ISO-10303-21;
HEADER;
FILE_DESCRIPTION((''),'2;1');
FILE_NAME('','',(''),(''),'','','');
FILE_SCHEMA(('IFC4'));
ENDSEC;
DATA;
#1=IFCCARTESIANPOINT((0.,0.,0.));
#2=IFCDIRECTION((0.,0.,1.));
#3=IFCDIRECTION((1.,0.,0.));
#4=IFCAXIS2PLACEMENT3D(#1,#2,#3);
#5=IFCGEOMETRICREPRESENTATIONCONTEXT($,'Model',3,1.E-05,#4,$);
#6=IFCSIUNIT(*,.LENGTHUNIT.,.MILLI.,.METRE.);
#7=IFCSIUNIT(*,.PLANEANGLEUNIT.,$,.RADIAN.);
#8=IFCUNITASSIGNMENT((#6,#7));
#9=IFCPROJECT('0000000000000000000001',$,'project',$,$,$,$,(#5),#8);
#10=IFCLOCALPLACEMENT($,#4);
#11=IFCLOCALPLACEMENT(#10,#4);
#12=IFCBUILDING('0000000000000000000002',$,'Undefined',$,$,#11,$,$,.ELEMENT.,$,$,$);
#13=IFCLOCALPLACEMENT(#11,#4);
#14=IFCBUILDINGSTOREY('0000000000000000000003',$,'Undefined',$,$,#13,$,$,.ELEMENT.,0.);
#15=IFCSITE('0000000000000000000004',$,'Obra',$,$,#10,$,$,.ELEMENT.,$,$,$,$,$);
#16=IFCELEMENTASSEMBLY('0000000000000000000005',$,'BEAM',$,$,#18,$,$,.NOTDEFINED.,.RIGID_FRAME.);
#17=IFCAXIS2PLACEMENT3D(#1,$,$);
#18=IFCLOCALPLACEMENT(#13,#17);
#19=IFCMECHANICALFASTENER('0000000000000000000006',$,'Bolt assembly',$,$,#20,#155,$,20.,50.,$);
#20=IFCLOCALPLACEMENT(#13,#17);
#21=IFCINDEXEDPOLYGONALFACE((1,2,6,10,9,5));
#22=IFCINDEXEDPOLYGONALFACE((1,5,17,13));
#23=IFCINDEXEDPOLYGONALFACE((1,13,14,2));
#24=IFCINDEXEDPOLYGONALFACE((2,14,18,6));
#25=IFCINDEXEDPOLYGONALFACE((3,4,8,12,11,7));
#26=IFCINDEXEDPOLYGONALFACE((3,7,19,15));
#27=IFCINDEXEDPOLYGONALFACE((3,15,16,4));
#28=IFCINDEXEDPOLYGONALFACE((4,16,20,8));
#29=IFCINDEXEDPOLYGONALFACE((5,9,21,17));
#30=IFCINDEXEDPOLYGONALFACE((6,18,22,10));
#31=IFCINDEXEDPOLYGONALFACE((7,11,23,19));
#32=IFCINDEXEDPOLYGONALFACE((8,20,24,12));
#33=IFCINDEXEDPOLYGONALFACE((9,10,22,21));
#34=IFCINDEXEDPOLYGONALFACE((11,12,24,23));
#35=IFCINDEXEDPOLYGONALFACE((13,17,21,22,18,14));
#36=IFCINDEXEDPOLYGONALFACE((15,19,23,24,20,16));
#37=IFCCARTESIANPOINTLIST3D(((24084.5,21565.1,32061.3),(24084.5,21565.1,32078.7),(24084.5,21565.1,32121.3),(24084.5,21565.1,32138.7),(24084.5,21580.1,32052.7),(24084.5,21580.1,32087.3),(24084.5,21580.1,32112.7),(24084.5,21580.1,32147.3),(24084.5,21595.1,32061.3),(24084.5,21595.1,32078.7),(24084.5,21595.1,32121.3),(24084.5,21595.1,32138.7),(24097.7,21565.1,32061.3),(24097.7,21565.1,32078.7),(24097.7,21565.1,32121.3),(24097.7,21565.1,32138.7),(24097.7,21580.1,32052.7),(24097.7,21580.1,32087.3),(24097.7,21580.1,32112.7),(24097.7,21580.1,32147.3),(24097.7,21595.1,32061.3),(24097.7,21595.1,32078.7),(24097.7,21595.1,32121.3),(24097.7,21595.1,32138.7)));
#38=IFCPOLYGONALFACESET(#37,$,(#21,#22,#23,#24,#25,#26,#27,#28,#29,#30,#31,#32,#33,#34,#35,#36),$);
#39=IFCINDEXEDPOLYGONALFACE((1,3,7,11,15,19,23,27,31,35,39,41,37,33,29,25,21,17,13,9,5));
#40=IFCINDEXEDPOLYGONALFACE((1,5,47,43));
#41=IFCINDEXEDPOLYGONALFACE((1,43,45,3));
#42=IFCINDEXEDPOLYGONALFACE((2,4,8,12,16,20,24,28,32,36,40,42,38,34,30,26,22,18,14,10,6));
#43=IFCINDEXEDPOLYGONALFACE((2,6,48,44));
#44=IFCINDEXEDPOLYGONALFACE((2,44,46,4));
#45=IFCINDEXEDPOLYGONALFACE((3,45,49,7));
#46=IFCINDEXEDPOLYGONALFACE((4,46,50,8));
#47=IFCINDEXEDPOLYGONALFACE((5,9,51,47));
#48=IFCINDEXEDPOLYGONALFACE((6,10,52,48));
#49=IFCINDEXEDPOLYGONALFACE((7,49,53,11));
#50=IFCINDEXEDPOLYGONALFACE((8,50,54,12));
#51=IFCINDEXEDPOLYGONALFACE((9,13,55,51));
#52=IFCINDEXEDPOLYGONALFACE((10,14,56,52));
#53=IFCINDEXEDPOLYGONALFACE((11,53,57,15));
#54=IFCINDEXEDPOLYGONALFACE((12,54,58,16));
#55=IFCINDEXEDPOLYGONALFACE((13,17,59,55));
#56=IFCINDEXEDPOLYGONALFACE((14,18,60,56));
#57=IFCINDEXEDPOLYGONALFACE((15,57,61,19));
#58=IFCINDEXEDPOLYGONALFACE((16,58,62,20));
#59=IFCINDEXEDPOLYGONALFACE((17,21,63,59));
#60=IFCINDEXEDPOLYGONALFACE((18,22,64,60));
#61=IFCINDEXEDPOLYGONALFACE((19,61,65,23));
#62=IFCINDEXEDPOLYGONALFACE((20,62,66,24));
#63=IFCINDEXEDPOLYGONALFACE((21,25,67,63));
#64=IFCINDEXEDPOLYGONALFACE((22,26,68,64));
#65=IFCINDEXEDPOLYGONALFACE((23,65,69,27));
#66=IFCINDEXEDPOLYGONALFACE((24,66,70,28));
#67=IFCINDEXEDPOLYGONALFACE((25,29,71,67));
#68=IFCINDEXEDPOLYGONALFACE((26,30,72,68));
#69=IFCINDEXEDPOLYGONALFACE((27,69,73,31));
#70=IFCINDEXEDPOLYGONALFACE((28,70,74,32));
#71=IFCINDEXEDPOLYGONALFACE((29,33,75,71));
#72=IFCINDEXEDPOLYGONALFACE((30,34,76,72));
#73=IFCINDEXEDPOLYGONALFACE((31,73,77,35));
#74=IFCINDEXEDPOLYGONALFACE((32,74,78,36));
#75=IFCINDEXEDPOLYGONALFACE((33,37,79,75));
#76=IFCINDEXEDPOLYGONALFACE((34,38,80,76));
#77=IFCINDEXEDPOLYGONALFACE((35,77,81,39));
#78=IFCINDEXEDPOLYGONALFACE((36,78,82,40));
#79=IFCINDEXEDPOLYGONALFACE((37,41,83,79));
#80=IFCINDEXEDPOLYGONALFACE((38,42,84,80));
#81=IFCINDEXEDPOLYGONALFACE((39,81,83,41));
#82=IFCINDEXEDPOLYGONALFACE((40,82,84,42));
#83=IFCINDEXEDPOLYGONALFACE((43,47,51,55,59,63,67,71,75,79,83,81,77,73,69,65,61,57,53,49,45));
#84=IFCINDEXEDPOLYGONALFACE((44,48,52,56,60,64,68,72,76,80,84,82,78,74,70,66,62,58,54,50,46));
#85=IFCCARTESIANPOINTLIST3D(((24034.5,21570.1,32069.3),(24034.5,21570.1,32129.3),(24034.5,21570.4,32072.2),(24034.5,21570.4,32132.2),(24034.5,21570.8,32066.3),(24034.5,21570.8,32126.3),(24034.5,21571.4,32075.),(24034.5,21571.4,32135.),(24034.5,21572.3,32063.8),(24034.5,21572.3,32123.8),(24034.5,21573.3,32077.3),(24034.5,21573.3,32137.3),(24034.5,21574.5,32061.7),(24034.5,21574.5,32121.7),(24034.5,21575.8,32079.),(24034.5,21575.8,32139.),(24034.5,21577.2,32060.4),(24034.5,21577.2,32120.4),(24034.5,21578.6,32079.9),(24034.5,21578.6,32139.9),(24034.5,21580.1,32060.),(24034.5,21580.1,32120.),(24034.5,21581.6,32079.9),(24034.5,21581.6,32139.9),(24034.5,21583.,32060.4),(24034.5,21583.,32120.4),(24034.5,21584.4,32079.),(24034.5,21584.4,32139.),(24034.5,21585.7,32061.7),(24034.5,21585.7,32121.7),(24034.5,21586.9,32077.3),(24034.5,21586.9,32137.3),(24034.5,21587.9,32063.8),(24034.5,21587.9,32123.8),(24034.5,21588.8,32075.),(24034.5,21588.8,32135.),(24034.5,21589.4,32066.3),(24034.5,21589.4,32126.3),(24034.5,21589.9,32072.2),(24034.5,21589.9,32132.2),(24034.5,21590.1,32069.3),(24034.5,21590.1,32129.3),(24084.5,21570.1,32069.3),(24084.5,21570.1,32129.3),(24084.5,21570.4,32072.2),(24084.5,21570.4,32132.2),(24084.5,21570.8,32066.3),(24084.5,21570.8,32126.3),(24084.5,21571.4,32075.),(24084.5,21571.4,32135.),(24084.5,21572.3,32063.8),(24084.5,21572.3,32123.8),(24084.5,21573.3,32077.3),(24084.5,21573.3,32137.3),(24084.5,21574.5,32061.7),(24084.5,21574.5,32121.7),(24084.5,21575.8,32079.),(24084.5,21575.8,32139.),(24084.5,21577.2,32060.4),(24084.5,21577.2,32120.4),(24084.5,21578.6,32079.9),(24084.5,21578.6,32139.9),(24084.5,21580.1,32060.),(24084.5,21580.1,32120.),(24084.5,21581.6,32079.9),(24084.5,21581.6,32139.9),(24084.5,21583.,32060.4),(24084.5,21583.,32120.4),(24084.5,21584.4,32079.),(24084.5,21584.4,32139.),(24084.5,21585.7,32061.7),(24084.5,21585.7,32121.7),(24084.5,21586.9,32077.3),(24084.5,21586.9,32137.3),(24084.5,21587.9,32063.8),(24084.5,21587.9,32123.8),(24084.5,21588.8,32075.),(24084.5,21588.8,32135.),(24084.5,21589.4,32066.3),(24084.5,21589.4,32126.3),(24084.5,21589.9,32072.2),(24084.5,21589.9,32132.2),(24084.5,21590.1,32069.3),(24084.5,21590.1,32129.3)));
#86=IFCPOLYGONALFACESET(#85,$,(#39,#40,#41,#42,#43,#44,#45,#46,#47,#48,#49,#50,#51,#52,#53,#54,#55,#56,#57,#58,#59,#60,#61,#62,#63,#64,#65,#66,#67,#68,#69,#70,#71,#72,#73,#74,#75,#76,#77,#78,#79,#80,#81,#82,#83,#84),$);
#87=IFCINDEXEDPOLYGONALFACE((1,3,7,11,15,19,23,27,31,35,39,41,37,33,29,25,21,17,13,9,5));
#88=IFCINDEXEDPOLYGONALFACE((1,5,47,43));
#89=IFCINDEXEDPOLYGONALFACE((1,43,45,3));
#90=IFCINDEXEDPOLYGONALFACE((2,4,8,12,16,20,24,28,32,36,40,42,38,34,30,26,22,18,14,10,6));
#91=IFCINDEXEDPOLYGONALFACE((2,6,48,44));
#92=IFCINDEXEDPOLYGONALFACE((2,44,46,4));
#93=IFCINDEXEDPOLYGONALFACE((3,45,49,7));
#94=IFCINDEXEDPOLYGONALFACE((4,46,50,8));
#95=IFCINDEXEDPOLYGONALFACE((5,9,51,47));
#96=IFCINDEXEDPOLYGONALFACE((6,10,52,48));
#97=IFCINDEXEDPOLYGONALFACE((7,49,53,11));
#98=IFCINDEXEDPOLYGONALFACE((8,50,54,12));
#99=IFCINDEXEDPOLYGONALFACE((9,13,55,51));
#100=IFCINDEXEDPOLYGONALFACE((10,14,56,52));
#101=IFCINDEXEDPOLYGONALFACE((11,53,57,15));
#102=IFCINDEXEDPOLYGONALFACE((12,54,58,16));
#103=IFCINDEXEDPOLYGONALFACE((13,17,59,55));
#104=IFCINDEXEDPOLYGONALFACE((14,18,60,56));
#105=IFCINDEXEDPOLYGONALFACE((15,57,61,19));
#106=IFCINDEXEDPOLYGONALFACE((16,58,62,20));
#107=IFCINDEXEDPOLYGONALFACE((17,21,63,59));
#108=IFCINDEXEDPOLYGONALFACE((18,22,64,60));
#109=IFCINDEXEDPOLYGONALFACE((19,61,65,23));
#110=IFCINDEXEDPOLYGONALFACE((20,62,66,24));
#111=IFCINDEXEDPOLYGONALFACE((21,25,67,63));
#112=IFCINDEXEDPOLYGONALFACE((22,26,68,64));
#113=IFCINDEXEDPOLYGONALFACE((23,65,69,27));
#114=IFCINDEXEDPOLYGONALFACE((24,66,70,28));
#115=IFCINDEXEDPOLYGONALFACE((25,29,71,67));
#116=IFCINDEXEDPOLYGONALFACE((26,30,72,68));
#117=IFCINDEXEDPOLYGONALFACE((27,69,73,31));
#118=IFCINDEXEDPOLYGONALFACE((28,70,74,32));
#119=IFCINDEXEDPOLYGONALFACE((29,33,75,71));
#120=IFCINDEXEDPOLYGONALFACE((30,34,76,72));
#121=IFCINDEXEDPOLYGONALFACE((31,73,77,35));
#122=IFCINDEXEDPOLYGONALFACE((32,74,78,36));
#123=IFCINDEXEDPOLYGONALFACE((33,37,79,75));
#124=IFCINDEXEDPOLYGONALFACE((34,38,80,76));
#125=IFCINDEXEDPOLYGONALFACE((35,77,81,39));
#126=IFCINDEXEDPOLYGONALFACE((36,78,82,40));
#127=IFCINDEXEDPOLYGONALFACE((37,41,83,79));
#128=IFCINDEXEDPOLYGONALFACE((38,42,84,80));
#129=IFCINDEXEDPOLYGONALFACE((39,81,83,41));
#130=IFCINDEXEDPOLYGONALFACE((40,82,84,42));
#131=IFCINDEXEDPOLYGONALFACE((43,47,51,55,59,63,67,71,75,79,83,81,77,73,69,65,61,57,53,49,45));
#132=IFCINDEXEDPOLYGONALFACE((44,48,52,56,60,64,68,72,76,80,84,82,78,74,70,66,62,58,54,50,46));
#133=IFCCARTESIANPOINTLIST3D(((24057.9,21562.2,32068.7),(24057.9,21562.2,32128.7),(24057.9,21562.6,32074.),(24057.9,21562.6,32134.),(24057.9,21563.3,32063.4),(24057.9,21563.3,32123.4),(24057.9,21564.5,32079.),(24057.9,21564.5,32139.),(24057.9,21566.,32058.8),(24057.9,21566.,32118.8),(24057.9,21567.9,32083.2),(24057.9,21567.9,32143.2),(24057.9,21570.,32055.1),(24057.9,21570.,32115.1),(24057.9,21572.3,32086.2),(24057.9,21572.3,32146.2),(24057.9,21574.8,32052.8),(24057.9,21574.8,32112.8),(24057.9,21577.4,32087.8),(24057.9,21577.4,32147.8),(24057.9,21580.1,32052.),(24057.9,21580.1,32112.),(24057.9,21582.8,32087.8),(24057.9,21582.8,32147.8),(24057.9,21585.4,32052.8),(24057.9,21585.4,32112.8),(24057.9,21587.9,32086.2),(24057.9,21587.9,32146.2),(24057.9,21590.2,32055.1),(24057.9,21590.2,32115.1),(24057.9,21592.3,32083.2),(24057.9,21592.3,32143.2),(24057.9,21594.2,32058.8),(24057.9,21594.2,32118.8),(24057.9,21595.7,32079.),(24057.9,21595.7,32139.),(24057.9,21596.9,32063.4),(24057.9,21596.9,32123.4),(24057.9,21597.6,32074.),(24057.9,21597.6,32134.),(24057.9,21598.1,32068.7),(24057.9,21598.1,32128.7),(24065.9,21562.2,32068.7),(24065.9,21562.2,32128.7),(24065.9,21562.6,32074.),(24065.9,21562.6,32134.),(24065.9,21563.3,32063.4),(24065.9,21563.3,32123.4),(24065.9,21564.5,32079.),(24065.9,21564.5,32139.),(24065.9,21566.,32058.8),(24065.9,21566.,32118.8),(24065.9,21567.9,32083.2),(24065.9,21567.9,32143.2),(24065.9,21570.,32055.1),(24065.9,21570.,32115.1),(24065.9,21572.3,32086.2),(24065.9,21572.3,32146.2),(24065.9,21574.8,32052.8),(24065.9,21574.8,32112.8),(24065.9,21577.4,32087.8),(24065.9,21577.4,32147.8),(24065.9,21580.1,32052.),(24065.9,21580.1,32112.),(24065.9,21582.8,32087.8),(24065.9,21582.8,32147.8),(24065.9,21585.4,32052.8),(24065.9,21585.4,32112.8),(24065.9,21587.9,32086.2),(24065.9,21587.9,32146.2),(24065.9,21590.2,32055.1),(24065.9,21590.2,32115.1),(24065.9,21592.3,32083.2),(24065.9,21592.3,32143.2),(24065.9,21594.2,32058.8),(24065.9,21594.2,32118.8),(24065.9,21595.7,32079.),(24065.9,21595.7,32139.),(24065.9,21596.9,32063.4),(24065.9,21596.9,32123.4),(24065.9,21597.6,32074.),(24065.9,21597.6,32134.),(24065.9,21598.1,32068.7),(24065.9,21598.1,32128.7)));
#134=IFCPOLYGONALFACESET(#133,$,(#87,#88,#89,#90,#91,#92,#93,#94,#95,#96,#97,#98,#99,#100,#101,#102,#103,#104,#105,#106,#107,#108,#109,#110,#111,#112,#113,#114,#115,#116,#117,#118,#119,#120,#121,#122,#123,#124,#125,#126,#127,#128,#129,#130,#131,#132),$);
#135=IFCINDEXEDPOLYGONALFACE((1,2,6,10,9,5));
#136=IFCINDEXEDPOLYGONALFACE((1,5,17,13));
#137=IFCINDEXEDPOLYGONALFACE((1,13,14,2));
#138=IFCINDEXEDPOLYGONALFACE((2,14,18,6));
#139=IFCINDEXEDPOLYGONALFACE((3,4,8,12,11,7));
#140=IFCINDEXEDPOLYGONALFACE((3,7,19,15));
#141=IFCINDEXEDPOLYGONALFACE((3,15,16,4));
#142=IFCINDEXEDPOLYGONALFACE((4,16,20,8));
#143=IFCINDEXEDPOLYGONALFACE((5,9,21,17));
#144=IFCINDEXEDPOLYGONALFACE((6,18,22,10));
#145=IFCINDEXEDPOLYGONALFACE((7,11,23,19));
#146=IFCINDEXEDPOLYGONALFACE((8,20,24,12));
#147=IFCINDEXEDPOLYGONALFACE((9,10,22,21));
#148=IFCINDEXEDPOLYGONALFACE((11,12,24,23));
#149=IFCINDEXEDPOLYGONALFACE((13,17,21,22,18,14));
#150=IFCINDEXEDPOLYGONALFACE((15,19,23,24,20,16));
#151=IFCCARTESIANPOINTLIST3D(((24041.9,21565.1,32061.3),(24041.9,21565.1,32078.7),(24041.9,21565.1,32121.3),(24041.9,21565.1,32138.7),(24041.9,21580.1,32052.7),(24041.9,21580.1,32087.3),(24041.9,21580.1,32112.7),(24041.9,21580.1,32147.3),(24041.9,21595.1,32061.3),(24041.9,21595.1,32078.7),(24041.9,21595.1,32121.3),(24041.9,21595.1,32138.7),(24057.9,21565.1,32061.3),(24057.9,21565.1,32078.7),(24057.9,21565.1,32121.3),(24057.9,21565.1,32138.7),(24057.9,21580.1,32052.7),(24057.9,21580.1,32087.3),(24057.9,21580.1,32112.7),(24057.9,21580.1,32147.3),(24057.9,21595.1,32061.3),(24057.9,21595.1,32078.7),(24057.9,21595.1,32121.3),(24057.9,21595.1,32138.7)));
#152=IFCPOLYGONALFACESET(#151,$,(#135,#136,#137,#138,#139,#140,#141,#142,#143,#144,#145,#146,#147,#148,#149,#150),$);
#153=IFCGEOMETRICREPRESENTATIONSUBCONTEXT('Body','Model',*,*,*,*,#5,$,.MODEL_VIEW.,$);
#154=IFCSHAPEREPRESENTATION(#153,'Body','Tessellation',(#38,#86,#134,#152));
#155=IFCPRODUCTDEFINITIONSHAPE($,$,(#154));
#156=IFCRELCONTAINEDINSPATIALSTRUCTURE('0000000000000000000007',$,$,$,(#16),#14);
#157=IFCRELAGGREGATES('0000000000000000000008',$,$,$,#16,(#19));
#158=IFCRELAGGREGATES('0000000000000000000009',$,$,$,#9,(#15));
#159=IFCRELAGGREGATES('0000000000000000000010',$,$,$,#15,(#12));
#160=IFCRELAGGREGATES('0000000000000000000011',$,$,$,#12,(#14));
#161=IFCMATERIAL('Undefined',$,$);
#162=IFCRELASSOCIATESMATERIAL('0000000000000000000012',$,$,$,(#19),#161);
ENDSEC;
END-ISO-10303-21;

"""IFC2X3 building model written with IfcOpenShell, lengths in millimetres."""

from ifc_helpers import new_model, si_unit, frame, origin_with_axes, origin_2d_with_axis, place, context, subcontext, project, spatial, polyline, circle, outline, extrude, source, transform, mapped, material, element, aggregate, save


model = new_model("IFC2X3")

# Units and contexts
model_context = context("Model", 3, precision=1e-05, world=origin_with_axes())
body_context = subcontext(model_context, "Body", "Model", "MODEL_VIEW")
ifc_project = project(units=[si_unit("LENGTHUNIT", "METRE", prefix="MILLI"), si_unit("PLANEANGLEUNIT", "RADIAN")], contexts=[model_context])

# Site, building, storey
site_placement = place(None, origin_with_axes())
site = spatial("IfcSite", under=ifc_project, at=site_placement, Name="Obra", CompositionType="ELEMENT")
building_placement = place(site_placement, origin_with_axes())
building = spatial("IfcBuilding", under=site, at=building_placement, Name="Undefined", CompositionType="ELEMENT")
storey_placement = place(building_placement, origin_with_axes())
storey = spatial("IfcBuildingStorey", under=building, at=storey_placement, Name="Undefined", CompositionType="ELEMENT", Elevation=0.0)

# Element assembly, mechanical fastener
assembly_1_placement = place(storey_placement, origin_with_axes())
assembly_1 = element("IfcElementAssembly", 1, at=assembly_1_placement, inside=storey, Name="BEAM", AssemblyPlace="NOTDEFINED", PredefinedType="RIGID_FRAME")
ifc_material_1 = material(Name="Undefined")
shared_shape_1 = source(origin_with_axes(), body_context, "Body", "SweptSolid", [
    extrude(outline(polyline([(17.3, 0.0), (8.7, 15.0), (-8.7, 15.0), (-17.3, 0.0), (-8.7, -15.0), (8.7, -15.0), (17.3, 0.0)])), frame((0.0, -27.5, 0.0), z_axis=(0.0, 1.0, 0.0), x_axis=(1.0, 0.0, 0.0)), (0.0, 0.0, 1.0), 13.2),
    extrude(circle(Radius=10.0, at=origin_2d_with_axis()), frame((0.0, -14.3, 0.0), z_axis=(0.0, 1.0, 0.0), x_axis=(1.0, 0.0, 0.0)), (0.0, 0.0, 1.0), 50.0),
    extrude(circle(Radius=18.0, at=origin_2d_with_axis()), frame((0.0, 4.3, 0.0), z_axis=(0.0, 1.0, 0.0), x_axis=(1.0, 0.0, 0.0)), (0.0, 0.0, 1.0), 8.0),
    extrude(outline(polyline([(17.3, 0.0), (8.7, 15.0), (-8.7, 15.0), (-17.3, 0.0), (-8.7, -15.0), (8.7, -15.0), (17.3, 0.0)])), frame((0.0, 12.3, 0.0), z_axis=(0.0, 1.0, 0.0), x_axis=(1.0, 0.0, 0.0)), (0.0, 0.0, 1.0), 16.0),
])
mechanical_fastener_1_placement = place(assembly_1_placement, frame((24070.2, 21540.1, 32170.0), z_axis=(0.0, 1.0, 0.0), x_axis=(0.0, 0.0, -1.0)))
mechanical_fastener_1 = element("IfcMechanicalFastener", 2, at=mechanical_fastener_1_placement, material=ifc_material_1, Name="Bolt assembly", NominalDiameter=20.0, NominalLength=50.0, context=body_context, shape_type="MappedRepresentation", body=[
    mapped(shared_shape_1, transform((40.0, 0.0, 40.0))),
    mapped(shared_shape_1, transform((100.0, 0.0, 40.0))),
])

aggregate(assembly_1, [mechanical_fastener_1])

save(model, "model.ifc")
